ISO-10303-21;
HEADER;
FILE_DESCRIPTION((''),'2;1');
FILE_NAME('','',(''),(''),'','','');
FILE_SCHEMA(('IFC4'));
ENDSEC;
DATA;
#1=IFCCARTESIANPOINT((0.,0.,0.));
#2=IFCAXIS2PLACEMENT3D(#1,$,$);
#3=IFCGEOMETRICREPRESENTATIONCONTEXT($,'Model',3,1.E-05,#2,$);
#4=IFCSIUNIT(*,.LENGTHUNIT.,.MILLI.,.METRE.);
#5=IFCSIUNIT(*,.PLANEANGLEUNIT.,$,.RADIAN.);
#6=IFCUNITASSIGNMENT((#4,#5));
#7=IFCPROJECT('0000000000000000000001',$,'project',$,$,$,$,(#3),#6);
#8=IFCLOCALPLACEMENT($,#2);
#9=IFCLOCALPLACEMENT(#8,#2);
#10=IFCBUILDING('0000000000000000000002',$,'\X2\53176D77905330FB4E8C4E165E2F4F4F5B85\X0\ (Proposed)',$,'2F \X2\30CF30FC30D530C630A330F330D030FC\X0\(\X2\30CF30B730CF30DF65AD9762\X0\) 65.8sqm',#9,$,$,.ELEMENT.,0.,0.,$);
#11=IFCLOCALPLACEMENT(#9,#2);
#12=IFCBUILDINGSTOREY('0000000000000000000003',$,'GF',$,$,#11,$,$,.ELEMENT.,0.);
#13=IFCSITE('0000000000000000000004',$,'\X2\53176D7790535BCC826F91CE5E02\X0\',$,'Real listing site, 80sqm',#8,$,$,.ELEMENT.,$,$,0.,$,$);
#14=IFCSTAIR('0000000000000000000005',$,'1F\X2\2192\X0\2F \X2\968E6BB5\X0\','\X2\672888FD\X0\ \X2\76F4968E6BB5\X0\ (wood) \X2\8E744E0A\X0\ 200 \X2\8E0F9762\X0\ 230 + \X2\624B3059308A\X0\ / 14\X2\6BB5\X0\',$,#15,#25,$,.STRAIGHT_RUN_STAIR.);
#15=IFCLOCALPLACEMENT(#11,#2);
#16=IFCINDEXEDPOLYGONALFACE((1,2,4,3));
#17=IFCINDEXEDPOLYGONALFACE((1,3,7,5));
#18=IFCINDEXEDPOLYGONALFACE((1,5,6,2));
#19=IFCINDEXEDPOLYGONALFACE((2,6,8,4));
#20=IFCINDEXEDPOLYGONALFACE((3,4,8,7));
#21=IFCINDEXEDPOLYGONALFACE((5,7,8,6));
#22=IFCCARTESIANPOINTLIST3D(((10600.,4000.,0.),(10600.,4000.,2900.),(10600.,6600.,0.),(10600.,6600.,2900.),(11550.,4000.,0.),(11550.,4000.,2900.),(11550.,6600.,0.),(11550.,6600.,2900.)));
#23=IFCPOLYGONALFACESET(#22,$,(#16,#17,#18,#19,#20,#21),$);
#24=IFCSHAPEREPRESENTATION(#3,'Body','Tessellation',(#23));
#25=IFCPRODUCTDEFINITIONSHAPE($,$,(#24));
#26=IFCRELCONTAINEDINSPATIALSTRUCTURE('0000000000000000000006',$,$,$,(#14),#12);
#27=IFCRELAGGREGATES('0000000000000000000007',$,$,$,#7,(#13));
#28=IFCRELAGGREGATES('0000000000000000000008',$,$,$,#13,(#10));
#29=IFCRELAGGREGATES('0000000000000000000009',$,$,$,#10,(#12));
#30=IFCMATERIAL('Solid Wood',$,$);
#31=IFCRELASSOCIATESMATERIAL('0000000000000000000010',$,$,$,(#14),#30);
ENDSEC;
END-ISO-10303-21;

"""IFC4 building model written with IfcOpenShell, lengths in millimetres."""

from ifc_helpers import new_model, si_unit, frame, frame_2d, origin, place, context, project, spatial, rectangle, extrude, material, element, save


model = new_model("IFC4")

# Units and contexts
model_context = context("Model", 3, precision=1e-05, world=origin())
ifc_project = project(units=[si_unit("LENGTHUNIT", "METRE", prefix="MILLI"), si_unit("PLANEANGLEUNIT", "RADIAN")], contexts=[model_context])

# Site, building, storey
site_placement = place(None, origin())
site = spatial("IfcSite", under=ifc_project, at=site_placement, Name="北海道富良野市", ObjectType="Real listing site, 80sqm", CompositionType="ELEMENT", RefElevation=0.0)
building_placement = place(site_placement, origin())
building = spatial("IfcBuilding", under=site, at=building_placement, Name="北海道・二世帯住宅 (Proposed)", ObjectType="2F ハーフティンバー(ハシハミ断面) 65.8sqm", CompositionType="ELEMENT", ElevationOfRefHeight=0.0, ElevationOfTerrain=0.0)
storey_placement = place(building_placement, origin())
storey = spatial("IfcBuildingStorey", under=building, at=storey_placement, Name="GF", CompositionType="ELEMENT", Elevation=0.0)

# Shared definitions
ifc_material_1 = material(Name="Solid Wood")

# Stair
stair_placement = place(storey_placement, frame((5300.0, 2000.0, 0.0)))
element("IfcStair", 1, at=stair_placement, inside=storey, material=ifc_material_1, Name="1F→2F 階段", Description="木製 直階段 (wood) 蹴上 200 踏面 230 + 手すり / 14段", PredefinedType="STRAIGHT_RUN_STAIR", context=model_context, shape_type="SweptSolid", body=[
    extrude(rectangle(XDim=950.0, YDim=2600.0, at=frame_2d((475.0, 1300.0))), frame((5300.0, 2000.0, 0.0)), (0.0, 0.0, 1.0), 2900.0),
])

save(model, "model.ifc")
